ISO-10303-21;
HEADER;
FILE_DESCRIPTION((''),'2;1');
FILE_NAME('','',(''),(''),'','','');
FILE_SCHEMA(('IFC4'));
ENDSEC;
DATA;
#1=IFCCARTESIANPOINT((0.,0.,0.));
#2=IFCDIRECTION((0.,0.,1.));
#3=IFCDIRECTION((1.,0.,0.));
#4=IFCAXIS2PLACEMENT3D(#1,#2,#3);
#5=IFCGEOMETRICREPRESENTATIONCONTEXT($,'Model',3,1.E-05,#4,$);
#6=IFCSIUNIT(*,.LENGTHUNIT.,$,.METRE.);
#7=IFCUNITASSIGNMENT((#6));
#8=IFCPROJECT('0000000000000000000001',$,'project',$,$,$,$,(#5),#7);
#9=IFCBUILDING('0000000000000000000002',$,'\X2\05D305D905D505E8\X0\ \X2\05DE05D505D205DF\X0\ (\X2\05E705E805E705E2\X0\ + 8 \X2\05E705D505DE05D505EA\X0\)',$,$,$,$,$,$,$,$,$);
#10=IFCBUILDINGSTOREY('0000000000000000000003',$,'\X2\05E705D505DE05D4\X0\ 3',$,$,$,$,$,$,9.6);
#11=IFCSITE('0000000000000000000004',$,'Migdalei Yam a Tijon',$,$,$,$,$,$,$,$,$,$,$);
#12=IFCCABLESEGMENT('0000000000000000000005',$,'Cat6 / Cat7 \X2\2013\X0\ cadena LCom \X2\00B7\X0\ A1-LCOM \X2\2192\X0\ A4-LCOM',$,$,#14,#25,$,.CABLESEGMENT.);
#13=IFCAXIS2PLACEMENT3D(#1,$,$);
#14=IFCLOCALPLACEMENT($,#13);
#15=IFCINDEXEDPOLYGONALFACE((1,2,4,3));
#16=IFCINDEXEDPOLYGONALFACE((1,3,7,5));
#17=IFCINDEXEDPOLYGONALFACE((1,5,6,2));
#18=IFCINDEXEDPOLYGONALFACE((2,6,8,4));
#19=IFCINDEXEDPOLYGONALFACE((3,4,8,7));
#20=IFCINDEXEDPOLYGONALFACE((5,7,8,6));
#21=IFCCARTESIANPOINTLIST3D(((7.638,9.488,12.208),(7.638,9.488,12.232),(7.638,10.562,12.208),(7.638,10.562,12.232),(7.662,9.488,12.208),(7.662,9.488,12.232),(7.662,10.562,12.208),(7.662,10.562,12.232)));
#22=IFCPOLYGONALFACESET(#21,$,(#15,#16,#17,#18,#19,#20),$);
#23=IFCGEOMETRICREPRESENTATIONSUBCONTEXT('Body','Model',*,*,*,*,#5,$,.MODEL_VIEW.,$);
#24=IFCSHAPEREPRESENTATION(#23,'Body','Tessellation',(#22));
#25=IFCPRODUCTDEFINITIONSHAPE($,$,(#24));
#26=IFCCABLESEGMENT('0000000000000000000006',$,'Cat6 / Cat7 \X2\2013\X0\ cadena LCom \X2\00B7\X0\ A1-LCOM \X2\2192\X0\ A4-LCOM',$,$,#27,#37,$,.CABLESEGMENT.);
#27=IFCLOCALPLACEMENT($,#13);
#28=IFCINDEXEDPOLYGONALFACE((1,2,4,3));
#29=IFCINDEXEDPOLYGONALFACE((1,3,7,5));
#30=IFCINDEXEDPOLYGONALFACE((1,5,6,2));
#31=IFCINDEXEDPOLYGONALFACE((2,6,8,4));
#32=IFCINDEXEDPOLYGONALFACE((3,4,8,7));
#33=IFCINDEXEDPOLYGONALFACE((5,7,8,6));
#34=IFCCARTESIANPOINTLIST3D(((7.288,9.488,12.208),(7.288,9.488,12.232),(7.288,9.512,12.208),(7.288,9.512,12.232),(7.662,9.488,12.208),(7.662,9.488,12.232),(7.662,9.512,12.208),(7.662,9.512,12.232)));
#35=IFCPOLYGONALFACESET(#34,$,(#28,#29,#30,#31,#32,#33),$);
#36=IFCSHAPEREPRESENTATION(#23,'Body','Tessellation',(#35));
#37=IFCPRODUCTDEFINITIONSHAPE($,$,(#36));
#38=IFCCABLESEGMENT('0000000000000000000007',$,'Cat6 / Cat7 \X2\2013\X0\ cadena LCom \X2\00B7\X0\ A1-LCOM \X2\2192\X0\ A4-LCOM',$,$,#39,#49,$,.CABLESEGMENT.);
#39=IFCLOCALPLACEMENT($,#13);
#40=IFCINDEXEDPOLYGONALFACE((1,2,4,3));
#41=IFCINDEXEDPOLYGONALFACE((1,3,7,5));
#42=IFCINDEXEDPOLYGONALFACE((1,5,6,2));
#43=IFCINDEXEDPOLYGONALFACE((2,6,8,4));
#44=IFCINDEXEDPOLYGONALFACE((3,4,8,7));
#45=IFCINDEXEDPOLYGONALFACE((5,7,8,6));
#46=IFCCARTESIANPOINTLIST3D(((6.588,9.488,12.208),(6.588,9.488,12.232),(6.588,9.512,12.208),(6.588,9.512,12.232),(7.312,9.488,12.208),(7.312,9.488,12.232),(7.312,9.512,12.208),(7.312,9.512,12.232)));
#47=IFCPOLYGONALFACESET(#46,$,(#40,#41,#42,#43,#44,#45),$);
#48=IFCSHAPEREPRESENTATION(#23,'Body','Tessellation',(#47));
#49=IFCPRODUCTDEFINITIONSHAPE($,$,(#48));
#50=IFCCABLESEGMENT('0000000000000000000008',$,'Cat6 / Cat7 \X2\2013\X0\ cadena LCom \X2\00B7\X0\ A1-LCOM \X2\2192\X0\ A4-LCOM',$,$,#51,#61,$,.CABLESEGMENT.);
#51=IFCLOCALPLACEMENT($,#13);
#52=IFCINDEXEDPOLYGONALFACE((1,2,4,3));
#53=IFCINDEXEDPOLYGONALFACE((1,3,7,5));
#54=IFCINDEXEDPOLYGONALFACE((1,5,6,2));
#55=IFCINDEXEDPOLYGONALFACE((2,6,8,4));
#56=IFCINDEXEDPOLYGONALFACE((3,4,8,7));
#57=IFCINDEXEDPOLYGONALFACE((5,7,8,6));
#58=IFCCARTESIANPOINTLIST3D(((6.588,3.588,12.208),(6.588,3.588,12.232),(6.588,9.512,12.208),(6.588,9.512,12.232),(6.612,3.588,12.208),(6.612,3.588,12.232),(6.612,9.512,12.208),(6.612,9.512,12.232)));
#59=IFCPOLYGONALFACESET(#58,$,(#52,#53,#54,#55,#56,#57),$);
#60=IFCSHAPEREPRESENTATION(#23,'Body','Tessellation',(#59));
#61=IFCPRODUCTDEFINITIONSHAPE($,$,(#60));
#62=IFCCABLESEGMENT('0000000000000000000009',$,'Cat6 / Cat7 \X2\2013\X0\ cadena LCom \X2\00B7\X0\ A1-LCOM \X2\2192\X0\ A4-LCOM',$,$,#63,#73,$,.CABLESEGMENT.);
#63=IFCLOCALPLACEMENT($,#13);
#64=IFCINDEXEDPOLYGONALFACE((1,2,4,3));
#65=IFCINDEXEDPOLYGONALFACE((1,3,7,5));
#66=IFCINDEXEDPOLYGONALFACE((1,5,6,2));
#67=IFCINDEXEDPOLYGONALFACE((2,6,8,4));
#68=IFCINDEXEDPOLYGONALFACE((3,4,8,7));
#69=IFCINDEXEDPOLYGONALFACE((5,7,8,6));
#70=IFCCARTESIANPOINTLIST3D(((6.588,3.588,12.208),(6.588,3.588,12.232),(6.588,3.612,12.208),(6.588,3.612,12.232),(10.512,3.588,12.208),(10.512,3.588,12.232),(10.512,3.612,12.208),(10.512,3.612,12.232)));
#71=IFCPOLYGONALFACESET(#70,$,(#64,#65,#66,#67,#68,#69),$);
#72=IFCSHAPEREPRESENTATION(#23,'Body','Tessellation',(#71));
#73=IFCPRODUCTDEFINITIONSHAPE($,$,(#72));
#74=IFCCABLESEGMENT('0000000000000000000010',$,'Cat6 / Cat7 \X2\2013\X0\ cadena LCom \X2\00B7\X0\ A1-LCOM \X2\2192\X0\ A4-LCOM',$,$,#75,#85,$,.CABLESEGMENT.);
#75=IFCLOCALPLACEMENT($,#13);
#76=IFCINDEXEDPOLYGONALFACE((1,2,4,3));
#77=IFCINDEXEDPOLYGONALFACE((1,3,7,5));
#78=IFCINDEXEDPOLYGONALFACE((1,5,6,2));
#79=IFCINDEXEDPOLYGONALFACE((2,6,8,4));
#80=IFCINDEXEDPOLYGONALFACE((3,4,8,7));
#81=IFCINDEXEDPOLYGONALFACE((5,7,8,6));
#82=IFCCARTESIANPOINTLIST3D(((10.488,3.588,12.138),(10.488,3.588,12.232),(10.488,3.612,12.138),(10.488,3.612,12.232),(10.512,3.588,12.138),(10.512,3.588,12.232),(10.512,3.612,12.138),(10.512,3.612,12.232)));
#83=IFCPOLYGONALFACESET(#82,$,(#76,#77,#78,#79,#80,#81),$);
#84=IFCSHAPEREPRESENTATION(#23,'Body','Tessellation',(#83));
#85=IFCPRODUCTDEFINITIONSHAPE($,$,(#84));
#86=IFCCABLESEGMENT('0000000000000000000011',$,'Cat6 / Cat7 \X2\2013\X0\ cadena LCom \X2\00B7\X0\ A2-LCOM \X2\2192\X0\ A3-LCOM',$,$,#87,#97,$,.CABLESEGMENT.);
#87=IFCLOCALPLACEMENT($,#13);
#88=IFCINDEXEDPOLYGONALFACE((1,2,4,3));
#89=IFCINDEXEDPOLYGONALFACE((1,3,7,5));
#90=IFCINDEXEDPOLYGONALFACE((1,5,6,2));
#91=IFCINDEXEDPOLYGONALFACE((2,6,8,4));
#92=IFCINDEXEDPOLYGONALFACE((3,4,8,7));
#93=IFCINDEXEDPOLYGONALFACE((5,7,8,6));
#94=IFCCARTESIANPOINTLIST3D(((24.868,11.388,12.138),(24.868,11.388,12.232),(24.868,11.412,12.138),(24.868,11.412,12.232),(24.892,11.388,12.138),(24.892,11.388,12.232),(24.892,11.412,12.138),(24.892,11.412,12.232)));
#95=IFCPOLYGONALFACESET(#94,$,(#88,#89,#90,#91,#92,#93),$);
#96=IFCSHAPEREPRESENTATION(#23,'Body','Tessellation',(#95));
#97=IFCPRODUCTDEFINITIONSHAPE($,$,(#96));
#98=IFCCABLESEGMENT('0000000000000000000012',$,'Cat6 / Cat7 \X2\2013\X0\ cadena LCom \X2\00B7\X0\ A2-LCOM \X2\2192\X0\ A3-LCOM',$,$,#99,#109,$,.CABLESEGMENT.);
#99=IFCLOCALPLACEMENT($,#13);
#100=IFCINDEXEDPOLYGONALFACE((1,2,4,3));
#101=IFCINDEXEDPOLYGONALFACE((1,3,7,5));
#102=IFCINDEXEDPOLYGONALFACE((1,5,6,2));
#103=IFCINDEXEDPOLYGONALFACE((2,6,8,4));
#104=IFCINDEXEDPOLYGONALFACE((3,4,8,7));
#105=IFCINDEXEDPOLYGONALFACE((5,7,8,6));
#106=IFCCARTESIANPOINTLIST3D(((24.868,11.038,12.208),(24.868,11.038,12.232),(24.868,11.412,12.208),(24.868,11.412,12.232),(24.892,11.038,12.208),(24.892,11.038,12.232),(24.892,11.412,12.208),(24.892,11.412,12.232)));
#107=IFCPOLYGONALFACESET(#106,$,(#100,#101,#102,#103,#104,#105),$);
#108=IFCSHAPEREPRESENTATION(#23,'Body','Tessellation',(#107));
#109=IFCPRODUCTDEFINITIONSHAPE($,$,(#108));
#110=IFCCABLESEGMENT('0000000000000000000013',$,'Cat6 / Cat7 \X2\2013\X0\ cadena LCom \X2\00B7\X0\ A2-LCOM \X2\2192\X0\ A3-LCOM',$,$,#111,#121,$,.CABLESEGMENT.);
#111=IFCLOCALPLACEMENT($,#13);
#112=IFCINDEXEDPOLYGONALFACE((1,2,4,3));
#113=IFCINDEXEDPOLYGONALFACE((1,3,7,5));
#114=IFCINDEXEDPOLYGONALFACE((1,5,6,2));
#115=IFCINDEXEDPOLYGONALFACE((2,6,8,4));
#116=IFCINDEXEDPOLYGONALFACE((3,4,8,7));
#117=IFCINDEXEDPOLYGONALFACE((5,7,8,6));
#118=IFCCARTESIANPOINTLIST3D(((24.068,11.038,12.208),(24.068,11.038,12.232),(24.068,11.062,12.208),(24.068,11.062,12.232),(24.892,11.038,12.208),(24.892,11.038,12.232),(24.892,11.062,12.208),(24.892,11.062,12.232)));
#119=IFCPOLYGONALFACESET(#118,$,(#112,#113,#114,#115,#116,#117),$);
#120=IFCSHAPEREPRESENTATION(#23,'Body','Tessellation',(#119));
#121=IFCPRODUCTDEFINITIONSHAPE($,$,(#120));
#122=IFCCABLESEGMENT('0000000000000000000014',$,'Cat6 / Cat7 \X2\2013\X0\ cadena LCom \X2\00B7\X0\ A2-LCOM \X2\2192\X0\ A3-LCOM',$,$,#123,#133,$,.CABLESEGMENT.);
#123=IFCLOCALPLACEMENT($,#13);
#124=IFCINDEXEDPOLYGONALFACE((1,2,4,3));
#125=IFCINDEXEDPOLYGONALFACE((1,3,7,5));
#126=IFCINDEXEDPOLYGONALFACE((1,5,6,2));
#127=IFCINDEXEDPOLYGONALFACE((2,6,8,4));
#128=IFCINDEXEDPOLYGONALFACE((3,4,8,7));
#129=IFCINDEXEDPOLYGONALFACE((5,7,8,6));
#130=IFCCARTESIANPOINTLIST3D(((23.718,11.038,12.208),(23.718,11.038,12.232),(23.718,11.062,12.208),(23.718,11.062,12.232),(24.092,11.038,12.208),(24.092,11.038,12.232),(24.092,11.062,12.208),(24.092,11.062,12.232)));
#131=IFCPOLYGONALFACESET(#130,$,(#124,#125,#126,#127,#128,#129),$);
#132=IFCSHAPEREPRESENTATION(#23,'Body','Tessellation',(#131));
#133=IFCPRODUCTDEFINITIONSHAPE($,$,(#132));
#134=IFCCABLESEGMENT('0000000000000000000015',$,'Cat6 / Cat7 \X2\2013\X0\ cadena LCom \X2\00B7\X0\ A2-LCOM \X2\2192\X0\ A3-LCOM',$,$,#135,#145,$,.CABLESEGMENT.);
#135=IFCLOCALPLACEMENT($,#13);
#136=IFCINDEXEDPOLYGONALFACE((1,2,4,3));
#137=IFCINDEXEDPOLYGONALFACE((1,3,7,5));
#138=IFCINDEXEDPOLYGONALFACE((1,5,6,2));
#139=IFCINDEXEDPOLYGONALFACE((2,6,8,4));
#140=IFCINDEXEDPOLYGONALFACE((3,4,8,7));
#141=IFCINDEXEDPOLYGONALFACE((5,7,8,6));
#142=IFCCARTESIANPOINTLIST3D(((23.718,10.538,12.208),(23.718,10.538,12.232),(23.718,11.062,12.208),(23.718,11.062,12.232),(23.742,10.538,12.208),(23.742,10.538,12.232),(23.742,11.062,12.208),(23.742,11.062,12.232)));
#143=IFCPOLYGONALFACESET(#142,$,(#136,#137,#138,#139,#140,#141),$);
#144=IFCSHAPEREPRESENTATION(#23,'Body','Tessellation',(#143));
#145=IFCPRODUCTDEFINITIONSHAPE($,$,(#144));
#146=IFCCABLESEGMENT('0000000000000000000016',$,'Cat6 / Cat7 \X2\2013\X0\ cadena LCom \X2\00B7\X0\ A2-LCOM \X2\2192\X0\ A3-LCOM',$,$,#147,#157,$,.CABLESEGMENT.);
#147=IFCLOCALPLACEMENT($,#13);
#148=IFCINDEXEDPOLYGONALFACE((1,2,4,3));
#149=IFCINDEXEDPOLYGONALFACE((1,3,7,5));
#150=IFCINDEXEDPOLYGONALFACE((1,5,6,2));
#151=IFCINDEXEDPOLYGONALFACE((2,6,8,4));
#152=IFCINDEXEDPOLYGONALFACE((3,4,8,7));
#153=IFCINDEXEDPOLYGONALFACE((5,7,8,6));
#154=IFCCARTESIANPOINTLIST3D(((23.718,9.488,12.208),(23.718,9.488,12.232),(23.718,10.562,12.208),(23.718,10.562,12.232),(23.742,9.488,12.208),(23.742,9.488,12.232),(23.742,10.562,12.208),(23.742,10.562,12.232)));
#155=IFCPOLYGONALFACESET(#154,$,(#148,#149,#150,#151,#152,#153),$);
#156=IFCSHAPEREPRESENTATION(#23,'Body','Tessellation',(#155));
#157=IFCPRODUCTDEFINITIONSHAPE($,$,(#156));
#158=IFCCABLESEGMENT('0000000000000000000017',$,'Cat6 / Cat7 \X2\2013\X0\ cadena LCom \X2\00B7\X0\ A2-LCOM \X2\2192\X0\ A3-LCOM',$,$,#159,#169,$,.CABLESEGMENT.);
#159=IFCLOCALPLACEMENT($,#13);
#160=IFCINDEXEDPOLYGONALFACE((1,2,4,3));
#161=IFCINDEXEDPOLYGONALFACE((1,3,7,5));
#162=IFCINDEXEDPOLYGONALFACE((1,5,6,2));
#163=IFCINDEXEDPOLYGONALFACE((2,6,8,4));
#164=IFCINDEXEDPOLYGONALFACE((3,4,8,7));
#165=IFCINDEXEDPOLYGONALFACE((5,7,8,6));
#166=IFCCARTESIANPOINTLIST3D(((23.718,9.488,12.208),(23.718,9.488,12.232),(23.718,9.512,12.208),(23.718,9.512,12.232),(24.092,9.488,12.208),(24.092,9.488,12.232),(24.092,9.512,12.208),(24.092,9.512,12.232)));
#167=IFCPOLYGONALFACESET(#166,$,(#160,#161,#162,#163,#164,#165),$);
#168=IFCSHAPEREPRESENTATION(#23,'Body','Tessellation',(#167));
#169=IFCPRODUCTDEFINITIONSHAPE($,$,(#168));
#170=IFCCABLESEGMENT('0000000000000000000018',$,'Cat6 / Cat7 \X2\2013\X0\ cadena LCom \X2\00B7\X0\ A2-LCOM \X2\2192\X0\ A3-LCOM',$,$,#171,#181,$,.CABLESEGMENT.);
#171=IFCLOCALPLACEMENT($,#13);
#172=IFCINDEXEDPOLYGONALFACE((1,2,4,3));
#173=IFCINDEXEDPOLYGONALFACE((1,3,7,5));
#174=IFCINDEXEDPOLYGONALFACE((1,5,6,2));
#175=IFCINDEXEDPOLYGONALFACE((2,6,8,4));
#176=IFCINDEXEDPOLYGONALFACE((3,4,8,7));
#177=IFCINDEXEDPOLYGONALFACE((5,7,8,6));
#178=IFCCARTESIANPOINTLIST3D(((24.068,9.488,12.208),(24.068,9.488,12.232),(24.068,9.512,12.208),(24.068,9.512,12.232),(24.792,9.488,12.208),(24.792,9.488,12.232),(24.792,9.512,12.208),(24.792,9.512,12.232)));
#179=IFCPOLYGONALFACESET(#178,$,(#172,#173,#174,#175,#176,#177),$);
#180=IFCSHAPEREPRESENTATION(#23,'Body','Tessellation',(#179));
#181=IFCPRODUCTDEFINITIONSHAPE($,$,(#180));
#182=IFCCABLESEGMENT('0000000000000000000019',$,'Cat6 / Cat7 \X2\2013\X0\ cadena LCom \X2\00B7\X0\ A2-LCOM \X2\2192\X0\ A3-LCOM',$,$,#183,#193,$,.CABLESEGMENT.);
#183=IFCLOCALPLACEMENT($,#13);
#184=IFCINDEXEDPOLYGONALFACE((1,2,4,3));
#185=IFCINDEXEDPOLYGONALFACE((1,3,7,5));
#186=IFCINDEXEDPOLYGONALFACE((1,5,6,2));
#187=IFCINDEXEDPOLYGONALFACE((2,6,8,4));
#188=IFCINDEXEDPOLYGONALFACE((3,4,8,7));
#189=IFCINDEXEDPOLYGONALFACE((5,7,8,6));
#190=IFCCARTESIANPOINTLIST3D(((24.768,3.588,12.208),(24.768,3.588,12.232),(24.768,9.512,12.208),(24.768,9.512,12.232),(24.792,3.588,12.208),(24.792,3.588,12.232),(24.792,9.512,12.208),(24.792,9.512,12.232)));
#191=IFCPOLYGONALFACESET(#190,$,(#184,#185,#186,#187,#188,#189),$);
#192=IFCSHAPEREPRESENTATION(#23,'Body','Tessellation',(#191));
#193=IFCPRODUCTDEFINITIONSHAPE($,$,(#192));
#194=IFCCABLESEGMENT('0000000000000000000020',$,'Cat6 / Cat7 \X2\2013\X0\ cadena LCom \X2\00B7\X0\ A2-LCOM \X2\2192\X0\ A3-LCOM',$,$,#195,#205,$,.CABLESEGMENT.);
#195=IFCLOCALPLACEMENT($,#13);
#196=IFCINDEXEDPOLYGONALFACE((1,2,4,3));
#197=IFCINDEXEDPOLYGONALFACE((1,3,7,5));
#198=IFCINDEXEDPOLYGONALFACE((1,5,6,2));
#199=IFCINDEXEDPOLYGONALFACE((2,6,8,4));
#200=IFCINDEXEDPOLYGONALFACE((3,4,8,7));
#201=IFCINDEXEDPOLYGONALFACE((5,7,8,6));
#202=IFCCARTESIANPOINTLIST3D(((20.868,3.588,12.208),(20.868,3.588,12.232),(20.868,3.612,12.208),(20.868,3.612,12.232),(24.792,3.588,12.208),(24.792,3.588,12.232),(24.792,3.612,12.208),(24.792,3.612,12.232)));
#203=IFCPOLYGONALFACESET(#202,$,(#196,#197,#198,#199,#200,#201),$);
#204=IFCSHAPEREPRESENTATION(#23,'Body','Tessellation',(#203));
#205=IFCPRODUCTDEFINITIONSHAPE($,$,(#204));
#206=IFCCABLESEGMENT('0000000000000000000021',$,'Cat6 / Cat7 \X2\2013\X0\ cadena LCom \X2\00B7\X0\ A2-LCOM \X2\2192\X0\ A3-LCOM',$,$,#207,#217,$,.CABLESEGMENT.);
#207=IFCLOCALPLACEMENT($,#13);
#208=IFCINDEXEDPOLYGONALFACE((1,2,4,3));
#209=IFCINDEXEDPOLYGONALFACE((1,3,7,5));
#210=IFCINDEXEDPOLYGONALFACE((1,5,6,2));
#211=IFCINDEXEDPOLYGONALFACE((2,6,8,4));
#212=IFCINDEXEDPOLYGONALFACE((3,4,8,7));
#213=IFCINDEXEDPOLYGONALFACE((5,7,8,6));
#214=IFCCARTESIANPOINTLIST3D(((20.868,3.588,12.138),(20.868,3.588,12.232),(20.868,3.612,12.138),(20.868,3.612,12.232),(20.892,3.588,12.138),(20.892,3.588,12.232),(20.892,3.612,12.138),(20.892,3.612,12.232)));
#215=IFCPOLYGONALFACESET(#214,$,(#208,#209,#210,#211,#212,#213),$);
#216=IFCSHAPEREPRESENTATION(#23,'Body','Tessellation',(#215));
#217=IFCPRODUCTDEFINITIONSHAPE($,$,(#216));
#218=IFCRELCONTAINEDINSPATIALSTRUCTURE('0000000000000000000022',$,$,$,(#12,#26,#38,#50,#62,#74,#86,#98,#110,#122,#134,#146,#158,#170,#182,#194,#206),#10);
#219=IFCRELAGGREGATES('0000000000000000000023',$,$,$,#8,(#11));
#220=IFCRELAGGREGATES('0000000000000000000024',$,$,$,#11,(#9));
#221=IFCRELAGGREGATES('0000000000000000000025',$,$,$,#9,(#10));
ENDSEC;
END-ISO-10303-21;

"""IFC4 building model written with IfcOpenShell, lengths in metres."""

from ifc_helpers import new_model, si_unit, frame, origin_with_axes, context, subcontext, project, spatial, line, indexed_curve, outline, extrude, element, save


model = new_model("IFC4")

# Units and contexts
model_context = context("Model", 3, precision=1e-05, world=origin_with_axes())
body_context = subcontext(model_context, "Body", "Model", "MODEL_VIEW")
ifc_project = project(units=[si_unit("LENGTHUNIT", "METRE")], contexts=[model_context])

# Site, building, storey
site = spatial("IfcSite", under=ifc_project, Name="Migdalei Yam a Tijon")
building = spatial("IfcBuilding", under=site, Name="דיור מוגן (קרקע + 8 קומות)")
storey = spatial("IfcBuildingStorey", under=building, Name="קומה 3", Elevation=9.6)

# Cable segments
element("IfcCableSegment", 1, inside=storey, Name="Cat6 / Cat7 – cadena LCom · A1-LCOM → A4-LCOM", PredefinedType="CABLESEGMENT", context=body_context, shape_type="SweptSolid", body=[
    extrude(outline(indexed_curve([(0.0, 0.0), (0.024, 0.0), (0.024, 1.074), (0.0, 1.074)], segments=[line(1, 2, 3, 4, 1)])), frame((7.638, 9.488, 12.208), z_axis=(0.0, 0.0, 1.0), x_axis=(1.0, 0.0, 0.0)), (0.0, 0.0, 1.0), 0.024),
])
element("IfcCableSegment", 2, inside=storey, Name="Cat6 / Cat7 – cadena LCom · A1-LCOM → A4-LCOM", PredefinedType="CABLESEGMENT", context=body_context, shape_type="SweptSolid", body=[
    extrude(outline(indexed_curve([(0.0, 0.0), (0.374, 0.0), (0.374, 0.024), (0.0, 0.024)], segments=[line(1, 2, 3, 4, 1)])), frame((7.288, 9.488, 12.208), z_axis=(0.0, 0.0, 1.0), x_axis=(1.0, 0.0, 0.0)), (0.0, 0.0, 1.0), 0.024),
])
element("IfcCableSegment", 3, inside=storey, Name="Cat6 / Cat7 – cadena LCom · A1-LCOM → A4-LCOM", PredefinedType="CABLESEGMENT", context=body_context, shape_type="SweptSolid", body=[
    extrude(outline(indexed_curve([(0.0, 0.0), (0.724, 0.0), (0.724, 0.024), (0.0, 0.024)], segments=[line(1, 2, 3, 4, 1)])), frame((6.588, 9.488, 12.208), z_axis=(0.0, 0.0, 1.0), x_axis=(1.0, 0.0, 0.0)), (0.0, 0.0, 1.0), 0.024),
])
element("IfcCableSegment", 4, inside=storey, Name="Cat6 / Cat7 – cadena LCom · A1-LCOM → A4-LCOM", PredefinedType="CABLESEGMENT", context=body_context, shape_type="SweptSolid", body=[
    extrude(outline(indexed_curve([(0.0, 0.0), (0.024, 0.0), (0.024, 5.924), (0.0, 5.924)], segments=[line(1, 2, 3, 4, 1)])), frame((6.588, 3.588, 12.208), z_axis=(0.0, 0.0, 1.0), x_axis=(1.0, 0.0, 0.0)), (0.0, 0.0, 1.0), 0.024),
])
element("IfcCableSegment", 5, inside=storey, Name="Cat6 / Cat7 – cadena LCom · A1-LCOM → A4-LCOM", PredefinedType="CABLESEGMENT", context=body_context, shape_type="SweptSolid", body=[
    extrude(outline(indexed_curve([(0.0, 0.0), (3.924, 0.0), (3.924, 0.024), (0.0, 0.024)], segments=[line(1, 2, 3, 4, 1)])), frame((6.588, 3.588, 12.208), z_axis=(0.0, 0.0, 1.0), x_axis=(1.0, 0.0, 0.0)), (0.0, 0.0, 1.0), 0.024),
])
element("IfcCableSegment", 6, inside=storey, Name="Cat6 / Cat7 – cadena LCom · A1-LCOM → A4-LCOM", PredefinedType="CABLESEGMENT", context=body_context, shape_type="SweptSolid", body=[
    extrude(outline(indexed_curve([(0.0, 0.0), (0.024, 0.0), (0.024, 0.024), (0.0, 0.024)], segments=[line(1, 2, 3, 4, 1)])), frame((10.488, 3.588, 12.138), z_axis=(0.0, 0.0, 1.0), x_axis=(1.0, 0.0, 0.0)), (0.0, 0.0, 1.0), 0.094),
])
element("IfcCableSegment", 7, inside=storey, Name="Cat6 / Cat7 – cadena LCom · A2-LCOM → A3-LCOM", PredefinedType="CABLESEGMENT", context=body_context, shape_type="SweptSolid", body=[
    extrude(outline(indexed_curve([(0.0, 0.0), (0.024, 0.0), (0.024, 0.024), (0.0, 0.024)], segments=[line(1, 2, 3, 4, 1)])), frame((24.868, 11.388, 12.138), z_axis=(0.0, 0.0, 1.0), x_axis=(1.0, 0.0, 0.0)), (0.0, 0.0, 1.0), 0.094),
])
element("IfcCableSegment", 8, inside=storey, Name="Cat6 / Cat7 – cadena LCom · A2-LCOM → A3-LCOM", PredefinedType="CABLESEGMENT", context=body_context, shape_type="SweptSolid", body=[
    extrude(outline(indexed_curve([(0.0, 0.0), (0.024, 0.0), (0.024, 0.374), (0.0, 0.374)], segments=[line(1, 2, 3, 4, 1)])), frame((24.868, 11.038, 12.208), z_axis=(0.0, 0.0, 1.0), x_axis=(1.0, 0.0, 0.0)), (0.0, 0.0, 1.0), 0.024),
])
element("IfcCableSegment", 9, inside=storey, Name="Cat6 / Cat7 – cadena LCom · A2-LCOM → A3-LCOM", PredefinedType="CABLESEGMENT", context=body_context, shape_type="SweptSolid", body=[
    extrude(outline(indexed_curve([(0.0, 0.0), (0.824, 0.0), (0.824, 0.024), (0.0, 0.024)], segments=[line(1, 2, 3, 4, 1)])), frame((24.068, 11.038, 12.208), z_axis=(0.0, 0.0, 1.0), x_axis=(1.0, 0.0, 0.0)), (0.0, 0.0, 1.0), 0.024),
])
element("IfcCableSegment", 10, inside=storey, Name="Cat6 / Cat7 – cadena LCom · A2-LCOM → A3-LCOM", PredefinedType="CABLESEGMENT", context=body_context, shape_type="SweptSolid", body=[
    extrude(outline(indexed_curve([(0.0, 0.0), (0.374, 0.0), (0.374, 0.024), (0.0, 0.024)], segments=[line(1, 2, 3, 4, 1)])), frame((23.718, 11.038, 12.208), z_axis=(0.0, 0.0, 1.0), x_axis=(1.0, 0.0, 0.0)), (0.0, 0.0, 1.0), 0.024),
])
element("IfcCableSegment", 11, inside=storey, Name="Cat6 / Cat7 – cadena LCom · A2-LCOM → A3-LCOM", PredefinedType="CABLESEGMENT", context=body_context, shape_type="SweptSolid", body=[
    extrude(outline(indexed_curve([(0.0, 0.0), (0.024, 0.0), (0.024, 0.524), (0.0, 0.524)], segments=[line(1, 2, 3, 4, 1)])), frame((23.718, 10.538, 12.208), z_axis=(0.0, 0.0, 1.0), x_axis=(1.0, 0.0, 0.0)), (0.0, 0.0, 1.0), 0.024),
])
element("IfcCableSegment", 12, inside=storey, Name="Cat6 / Cat7 – cadena LCom · A2-LCOM → A3-LCOM", PredefinedType="CABLESEGMENT", context=body_context, shape_type="SweptSolid", body=[
    extrude(outline(indexed_curve([(0.0, 0.0), (0.024, 0.0), (0.024, 1.074), (0.0, 1.074)], segments=[line(1, 2, 3, 4, 1)])), frame((23.718, 9.488, 12.208), z_axis=(0.0, 0.0, 1.0), x_axis=(1.0, 0.0, 0.0)), (0.0, 0.0, 1.0), 0.024),
])
element("IfcCableSegment", 13, inside=storey, Name="Cat6 / Cat7 – cadena LCom · A2-LCOM → A3-LCOM", PredefinedType="CABLESEGMENT", context=body_context, shape_type="SweptSolid", body=[
    extrude(outline(indexed_curve([(0.0, 0.0), (0.374, 0.0), (0.374, 0.024), (0.0, 0.024)], segments=[line(1, 2, 3, 4, 1)])), frame((23.718, 9.488, 12.208), z_axis=(0.0, 0.0, 1.0), x_axis=(1.0, 0.0, 0.0)), (0.0, 0.0, 1.0), 0.024),
])
element("IfcCableSegment", 14, inside=storey, Name="Cat6 / Cat7 – cadena LCom · A2-LCOM → A3-LCOM", PredefinedType="CABLESEGMENT", context=body_context, shape_type="SweptSolid", body=[
    extrude(outline(indexed_curve([(0.0, 0.0), (0.724, 0.0), (0.724, 0.024), (0.0, 0.024)], segments=[line(1, 2, 3, 4, 1)])), frame((24.068, 9.488, 12.208), z_axis=(0.0, 0.0, 1.0), x_axis=(1.0, 0.0, 0.0)), (0.0, 0.0, 1.0), 0.024),
])
element("IfcCableSegment", 15, inside=storey, Name="Cat6 / Cat7 – cadena LCom · A2-LCOM → A3-LCOM", PredefinedType="CABLESEGMENT", context=body_context, shape_type="SweptSolid", body=[
    extrude(outline(indexed_curve([(0.0, 0.0), (0.024, 0.0), (0.024, 5.924), (0.0, 5.924)], segments=[line(1, 2, 3, 4, 1)])), frame((24.768, 3.588, 12.208), z_axis=(0.0, 0.0, 1.0), x_axis=(1.0, 0.0, 0.0)), (0.0, 0.0, 1.0), 0.024),
])
element("IfcCableSegment", 16, inside=storey, Name="Cat6 / Cat7 – cadena LCom · A2-LCOM → A3-LCOM", PredefinedType="CABLESEGMENT", context=body_context, shape_type="SweptSolid", body=[
    extrude(outline(indexed_curve([(0.0, 0.0), (3.924, 0.0), (3.924, 0.024), (0.0, 0.024)], segments=[line(1, 2, 3, 4, 1)])), frame((20.868, 3.588, 12.208), z_axis=(0.0, 0.0, 1.0), x_axis=(1.0, 0.0, 0.0)), (0.0, 0.0, 1.0), 0.024),
])
element("IfcCableSegment", 17, inside=storey, Name="Cat6 / Cat7 – cadena LCom · A2-LCOM → A3-LCOM", PredefinedType="CABLESEGMENT", context=body_context, shape_type="SweptSolid", body=[
    extrude(outline(indexed_curve([(0.0, 0.0), (0.024, 0.0), (0.024, 0.024), (0.0, 0.024)], segments=[line(1, 2, 3, 4, 1)])), frame((20.868, 3.588, 12.138), z_axis=(0.0, 0.0, 1.0), x_axis=(1.0, 0.0, 0.0)), (0.0, 0.0, 1.0), 0.094),
])

save(model, "model.ifc")
